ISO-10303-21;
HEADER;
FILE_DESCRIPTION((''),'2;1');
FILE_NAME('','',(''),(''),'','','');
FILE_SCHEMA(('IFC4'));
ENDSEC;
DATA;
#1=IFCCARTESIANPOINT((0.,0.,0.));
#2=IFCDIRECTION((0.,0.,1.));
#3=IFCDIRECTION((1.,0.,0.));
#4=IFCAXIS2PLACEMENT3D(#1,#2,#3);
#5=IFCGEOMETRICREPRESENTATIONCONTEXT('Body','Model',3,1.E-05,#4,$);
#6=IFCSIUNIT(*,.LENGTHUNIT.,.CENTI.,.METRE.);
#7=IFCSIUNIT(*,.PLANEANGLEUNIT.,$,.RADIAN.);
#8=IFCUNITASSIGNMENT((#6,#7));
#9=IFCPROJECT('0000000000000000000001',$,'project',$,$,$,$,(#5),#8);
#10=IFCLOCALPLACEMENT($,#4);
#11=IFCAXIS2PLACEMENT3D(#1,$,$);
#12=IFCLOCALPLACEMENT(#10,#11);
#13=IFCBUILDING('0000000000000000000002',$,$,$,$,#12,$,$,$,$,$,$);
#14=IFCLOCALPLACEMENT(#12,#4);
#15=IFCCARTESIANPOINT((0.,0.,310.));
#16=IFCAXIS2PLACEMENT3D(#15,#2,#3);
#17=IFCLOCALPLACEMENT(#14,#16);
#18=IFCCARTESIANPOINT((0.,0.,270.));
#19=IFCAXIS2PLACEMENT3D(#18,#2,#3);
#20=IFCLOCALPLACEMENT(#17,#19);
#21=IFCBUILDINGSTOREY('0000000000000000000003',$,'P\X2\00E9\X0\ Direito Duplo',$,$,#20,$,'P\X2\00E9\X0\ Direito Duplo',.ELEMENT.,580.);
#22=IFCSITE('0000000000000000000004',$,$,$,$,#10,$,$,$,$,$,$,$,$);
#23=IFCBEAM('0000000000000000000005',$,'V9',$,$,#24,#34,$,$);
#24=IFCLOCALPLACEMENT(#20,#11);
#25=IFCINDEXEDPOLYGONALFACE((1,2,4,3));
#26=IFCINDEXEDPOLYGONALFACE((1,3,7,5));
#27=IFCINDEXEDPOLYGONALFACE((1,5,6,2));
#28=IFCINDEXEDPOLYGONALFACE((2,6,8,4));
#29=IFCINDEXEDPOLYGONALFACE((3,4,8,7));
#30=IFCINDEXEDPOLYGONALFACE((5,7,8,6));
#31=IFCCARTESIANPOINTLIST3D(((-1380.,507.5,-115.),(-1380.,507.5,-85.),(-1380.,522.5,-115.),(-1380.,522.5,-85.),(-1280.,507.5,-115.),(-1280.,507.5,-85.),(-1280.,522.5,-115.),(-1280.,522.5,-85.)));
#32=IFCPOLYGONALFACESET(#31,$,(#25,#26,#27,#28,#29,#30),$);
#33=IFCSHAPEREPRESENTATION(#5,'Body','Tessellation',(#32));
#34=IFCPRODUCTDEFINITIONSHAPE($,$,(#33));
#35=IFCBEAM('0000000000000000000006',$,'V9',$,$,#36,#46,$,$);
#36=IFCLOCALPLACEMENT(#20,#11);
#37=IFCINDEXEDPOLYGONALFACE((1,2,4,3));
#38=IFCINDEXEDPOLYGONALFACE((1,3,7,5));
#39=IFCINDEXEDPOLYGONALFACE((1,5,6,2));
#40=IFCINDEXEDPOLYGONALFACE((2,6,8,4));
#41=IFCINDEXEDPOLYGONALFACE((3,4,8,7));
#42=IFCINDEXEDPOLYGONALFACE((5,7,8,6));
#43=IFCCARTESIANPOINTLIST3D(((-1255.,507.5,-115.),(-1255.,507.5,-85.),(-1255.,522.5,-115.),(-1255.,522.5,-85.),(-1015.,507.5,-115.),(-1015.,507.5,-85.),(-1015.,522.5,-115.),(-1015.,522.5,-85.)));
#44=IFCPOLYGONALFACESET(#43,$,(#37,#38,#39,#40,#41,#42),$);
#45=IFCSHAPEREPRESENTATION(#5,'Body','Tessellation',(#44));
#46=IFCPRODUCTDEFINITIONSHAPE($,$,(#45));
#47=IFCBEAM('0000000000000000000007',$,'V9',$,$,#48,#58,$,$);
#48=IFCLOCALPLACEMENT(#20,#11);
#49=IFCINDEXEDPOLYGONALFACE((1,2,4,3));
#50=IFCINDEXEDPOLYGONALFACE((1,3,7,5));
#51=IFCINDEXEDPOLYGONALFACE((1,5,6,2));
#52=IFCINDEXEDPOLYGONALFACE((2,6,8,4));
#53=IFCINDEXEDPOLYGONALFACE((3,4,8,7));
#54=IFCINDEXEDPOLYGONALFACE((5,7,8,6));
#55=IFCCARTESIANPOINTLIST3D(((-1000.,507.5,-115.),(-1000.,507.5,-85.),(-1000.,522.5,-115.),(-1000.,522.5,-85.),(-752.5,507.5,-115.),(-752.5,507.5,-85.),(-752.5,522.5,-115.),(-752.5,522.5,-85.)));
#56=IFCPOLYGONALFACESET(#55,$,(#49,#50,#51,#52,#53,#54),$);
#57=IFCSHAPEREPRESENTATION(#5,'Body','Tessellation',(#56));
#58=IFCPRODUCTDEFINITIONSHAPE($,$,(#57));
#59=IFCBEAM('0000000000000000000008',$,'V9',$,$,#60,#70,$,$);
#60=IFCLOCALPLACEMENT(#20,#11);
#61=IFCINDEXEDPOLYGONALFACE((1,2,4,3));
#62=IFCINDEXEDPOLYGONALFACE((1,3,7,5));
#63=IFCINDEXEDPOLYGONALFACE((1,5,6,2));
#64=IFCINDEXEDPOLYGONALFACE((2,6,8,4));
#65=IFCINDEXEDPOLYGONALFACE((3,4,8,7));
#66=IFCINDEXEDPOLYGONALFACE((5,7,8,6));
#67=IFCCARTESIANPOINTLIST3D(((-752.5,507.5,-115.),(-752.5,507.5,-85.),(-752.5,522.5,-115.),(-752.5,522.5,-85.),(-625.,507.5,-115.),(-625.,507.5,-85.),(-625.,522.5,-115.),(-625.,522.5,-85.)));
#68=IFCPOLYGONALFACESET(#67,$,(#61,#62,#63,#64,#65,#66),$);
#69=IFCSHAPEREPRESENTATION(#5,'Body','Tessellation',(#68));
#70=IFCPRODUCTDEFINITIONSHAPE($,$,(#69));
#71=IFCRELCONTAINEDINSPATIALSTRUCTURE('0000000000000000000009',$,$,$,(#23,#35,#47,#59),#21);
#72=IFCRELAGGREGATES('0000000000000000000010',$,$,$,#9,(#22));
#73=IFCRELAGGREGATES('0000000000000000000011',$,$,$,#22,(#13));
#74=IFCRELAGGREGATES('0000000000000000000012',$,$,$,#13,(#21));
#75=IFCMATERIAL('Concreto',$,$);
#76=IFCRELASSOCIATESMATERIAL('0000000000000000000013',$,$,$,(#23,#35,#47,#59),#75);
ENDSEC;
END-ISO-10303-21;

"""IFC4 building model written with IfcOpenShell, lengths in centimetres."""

from ifc_helpers import new_model, si_unit, frame, origin, origin_with_axes, origin_2d_with_axis, place, context, project, spatial, rectangle, extrude, material, element, save


model = new_model("IFC4")

# Units and contexts
model_context = context("Model", 3, precision=1e-05, world=origin_with_axes(), identifier="Body")
ifc_project = project(units=[si_unit("LENGTHUNIT", "METRE", prefix="CENTI"), si_unit("PLANEANGLEUNIT", "RADIAN")], contexts=[model_context])

# Site, building, storey
site_placement = place(None, origin_with_axes())
site = spatial("IfcSite", under=ifc_project, at=site_placement)
building_placement = place(site_placement, origin())
building = spatial("IfcBuilding", under=site, at=building_placement)
placement_1 = place(building_placement, origin_with_axes())
placement_2 = place(placement_1, frame((0.0, 0.0, 310.0), z_axis=(0.0, 0.0, 1.0), x_axis=(1.0, 0.0, 0.0)))
storey_placement = place(placement_2, frame((0.0, 0.0, 270.0), z_axis=(0.0, 0.0, 1.0), x_axis=(1.0, 0.0, 0.0)))
storey = spatial("IfcBuildingStorey", under=building, at=storey_placement, Name="Pé Direito Duplo", LongName="Pé Direito Duplo", CompositionType="ELEMENT", Elevation=580.0)

# Shared definitions
ifc_material = material(Name="Concreto")

# Beams
beam_1_placement = place(storey_placement, frame((-1330.0, 515.0, -85.0), z_axis=(0.0, 0.0, 1.0), x_axis=(1.0, 0.0, 0.0)))
element("IfcBeam", 1, at=beam_1_placement, inside=storey, material=ifc_material, Name="V9", context=model_context, shape_type="SolidModel", body=[
    extrude(rectangle(XDim=15.0, YDim=30.0, at=origin_2d_with_axis()), frame((-50.0, 0.0, -15.0), z_axis=(1.0, 0.0, 0.0), x_axis=(0.0, -1.0, 0.0)), (0.0, 0.0, 1.0), 100.0),
])
beam_2_placement = place(storey_placement, frame((-1135.0, 515.0, -85.0), z_axis=(0.0, 0.0, 1.0), x_axis=(1.0, 0.0, 0.0)))
element("IfcBeam", 2, at=beam_2_placement, inside=storey, material=ifc_material, Name="V9", context=model_context, shape_type="SolidModel", body=[
    extrude(rectangle(XDim=15.0, YDim=30.0, at=origin_2d_with_axis()), frame((-120.0, 0.0, -15.0), z_axis=(1.0, 0.0, 0.0), x_axis=(0.0, -1.0, 0.0)), (0.0, 0.0, 1.0), 240.0),
])
beam_3_placement = place(storey_placement, frame((-876.25, 515.0, -85.0), z_axis=(0.0, 0.0, 1.0), x_axis=(1.0, 0.0, 0.0)))
element("IfcBeam", 3, at=beam_3_placement, inside=storey, material=ifc_material, Name="V9", context=model_context, shape_type="SolidModel", body=[
    extrude(rectangle(XDim=15.0, YDim=30.0, at=origin_2d_with_axis()), frame((-123.75, 0.0, -15.0), z_axis=(1.0, 0.0, 0.0), x_axis=(0.0, -1.0, 0.0)), (0.0, 0.0, 1.0), 247.5),
])
beam_4_placement = place(storey_placement, frame((-688.75, 515.0, -85.0), z_axis=(0.0, 0.0, 1.0), x_axis=(1.0, 0.0, 0.0)))
element("IfcBeam", 4, at=beam_4_placement, inside=storey, material=ifc_material, Name="V9", context=model_context, shape_type="SolidModel", body=[
    extrude(rectangle(XDim=15.0, YDim=30.0, at=origin_2d_with_axis()), frame((-63.75, 0.0, -15.0), z_axis=(1.0, 0.0, 0.0), x_axis=(0.0, 1.0, 0.0)), (0.0, 0.0, 1.0), 127.5),
])

save(model, "model.ifc")
